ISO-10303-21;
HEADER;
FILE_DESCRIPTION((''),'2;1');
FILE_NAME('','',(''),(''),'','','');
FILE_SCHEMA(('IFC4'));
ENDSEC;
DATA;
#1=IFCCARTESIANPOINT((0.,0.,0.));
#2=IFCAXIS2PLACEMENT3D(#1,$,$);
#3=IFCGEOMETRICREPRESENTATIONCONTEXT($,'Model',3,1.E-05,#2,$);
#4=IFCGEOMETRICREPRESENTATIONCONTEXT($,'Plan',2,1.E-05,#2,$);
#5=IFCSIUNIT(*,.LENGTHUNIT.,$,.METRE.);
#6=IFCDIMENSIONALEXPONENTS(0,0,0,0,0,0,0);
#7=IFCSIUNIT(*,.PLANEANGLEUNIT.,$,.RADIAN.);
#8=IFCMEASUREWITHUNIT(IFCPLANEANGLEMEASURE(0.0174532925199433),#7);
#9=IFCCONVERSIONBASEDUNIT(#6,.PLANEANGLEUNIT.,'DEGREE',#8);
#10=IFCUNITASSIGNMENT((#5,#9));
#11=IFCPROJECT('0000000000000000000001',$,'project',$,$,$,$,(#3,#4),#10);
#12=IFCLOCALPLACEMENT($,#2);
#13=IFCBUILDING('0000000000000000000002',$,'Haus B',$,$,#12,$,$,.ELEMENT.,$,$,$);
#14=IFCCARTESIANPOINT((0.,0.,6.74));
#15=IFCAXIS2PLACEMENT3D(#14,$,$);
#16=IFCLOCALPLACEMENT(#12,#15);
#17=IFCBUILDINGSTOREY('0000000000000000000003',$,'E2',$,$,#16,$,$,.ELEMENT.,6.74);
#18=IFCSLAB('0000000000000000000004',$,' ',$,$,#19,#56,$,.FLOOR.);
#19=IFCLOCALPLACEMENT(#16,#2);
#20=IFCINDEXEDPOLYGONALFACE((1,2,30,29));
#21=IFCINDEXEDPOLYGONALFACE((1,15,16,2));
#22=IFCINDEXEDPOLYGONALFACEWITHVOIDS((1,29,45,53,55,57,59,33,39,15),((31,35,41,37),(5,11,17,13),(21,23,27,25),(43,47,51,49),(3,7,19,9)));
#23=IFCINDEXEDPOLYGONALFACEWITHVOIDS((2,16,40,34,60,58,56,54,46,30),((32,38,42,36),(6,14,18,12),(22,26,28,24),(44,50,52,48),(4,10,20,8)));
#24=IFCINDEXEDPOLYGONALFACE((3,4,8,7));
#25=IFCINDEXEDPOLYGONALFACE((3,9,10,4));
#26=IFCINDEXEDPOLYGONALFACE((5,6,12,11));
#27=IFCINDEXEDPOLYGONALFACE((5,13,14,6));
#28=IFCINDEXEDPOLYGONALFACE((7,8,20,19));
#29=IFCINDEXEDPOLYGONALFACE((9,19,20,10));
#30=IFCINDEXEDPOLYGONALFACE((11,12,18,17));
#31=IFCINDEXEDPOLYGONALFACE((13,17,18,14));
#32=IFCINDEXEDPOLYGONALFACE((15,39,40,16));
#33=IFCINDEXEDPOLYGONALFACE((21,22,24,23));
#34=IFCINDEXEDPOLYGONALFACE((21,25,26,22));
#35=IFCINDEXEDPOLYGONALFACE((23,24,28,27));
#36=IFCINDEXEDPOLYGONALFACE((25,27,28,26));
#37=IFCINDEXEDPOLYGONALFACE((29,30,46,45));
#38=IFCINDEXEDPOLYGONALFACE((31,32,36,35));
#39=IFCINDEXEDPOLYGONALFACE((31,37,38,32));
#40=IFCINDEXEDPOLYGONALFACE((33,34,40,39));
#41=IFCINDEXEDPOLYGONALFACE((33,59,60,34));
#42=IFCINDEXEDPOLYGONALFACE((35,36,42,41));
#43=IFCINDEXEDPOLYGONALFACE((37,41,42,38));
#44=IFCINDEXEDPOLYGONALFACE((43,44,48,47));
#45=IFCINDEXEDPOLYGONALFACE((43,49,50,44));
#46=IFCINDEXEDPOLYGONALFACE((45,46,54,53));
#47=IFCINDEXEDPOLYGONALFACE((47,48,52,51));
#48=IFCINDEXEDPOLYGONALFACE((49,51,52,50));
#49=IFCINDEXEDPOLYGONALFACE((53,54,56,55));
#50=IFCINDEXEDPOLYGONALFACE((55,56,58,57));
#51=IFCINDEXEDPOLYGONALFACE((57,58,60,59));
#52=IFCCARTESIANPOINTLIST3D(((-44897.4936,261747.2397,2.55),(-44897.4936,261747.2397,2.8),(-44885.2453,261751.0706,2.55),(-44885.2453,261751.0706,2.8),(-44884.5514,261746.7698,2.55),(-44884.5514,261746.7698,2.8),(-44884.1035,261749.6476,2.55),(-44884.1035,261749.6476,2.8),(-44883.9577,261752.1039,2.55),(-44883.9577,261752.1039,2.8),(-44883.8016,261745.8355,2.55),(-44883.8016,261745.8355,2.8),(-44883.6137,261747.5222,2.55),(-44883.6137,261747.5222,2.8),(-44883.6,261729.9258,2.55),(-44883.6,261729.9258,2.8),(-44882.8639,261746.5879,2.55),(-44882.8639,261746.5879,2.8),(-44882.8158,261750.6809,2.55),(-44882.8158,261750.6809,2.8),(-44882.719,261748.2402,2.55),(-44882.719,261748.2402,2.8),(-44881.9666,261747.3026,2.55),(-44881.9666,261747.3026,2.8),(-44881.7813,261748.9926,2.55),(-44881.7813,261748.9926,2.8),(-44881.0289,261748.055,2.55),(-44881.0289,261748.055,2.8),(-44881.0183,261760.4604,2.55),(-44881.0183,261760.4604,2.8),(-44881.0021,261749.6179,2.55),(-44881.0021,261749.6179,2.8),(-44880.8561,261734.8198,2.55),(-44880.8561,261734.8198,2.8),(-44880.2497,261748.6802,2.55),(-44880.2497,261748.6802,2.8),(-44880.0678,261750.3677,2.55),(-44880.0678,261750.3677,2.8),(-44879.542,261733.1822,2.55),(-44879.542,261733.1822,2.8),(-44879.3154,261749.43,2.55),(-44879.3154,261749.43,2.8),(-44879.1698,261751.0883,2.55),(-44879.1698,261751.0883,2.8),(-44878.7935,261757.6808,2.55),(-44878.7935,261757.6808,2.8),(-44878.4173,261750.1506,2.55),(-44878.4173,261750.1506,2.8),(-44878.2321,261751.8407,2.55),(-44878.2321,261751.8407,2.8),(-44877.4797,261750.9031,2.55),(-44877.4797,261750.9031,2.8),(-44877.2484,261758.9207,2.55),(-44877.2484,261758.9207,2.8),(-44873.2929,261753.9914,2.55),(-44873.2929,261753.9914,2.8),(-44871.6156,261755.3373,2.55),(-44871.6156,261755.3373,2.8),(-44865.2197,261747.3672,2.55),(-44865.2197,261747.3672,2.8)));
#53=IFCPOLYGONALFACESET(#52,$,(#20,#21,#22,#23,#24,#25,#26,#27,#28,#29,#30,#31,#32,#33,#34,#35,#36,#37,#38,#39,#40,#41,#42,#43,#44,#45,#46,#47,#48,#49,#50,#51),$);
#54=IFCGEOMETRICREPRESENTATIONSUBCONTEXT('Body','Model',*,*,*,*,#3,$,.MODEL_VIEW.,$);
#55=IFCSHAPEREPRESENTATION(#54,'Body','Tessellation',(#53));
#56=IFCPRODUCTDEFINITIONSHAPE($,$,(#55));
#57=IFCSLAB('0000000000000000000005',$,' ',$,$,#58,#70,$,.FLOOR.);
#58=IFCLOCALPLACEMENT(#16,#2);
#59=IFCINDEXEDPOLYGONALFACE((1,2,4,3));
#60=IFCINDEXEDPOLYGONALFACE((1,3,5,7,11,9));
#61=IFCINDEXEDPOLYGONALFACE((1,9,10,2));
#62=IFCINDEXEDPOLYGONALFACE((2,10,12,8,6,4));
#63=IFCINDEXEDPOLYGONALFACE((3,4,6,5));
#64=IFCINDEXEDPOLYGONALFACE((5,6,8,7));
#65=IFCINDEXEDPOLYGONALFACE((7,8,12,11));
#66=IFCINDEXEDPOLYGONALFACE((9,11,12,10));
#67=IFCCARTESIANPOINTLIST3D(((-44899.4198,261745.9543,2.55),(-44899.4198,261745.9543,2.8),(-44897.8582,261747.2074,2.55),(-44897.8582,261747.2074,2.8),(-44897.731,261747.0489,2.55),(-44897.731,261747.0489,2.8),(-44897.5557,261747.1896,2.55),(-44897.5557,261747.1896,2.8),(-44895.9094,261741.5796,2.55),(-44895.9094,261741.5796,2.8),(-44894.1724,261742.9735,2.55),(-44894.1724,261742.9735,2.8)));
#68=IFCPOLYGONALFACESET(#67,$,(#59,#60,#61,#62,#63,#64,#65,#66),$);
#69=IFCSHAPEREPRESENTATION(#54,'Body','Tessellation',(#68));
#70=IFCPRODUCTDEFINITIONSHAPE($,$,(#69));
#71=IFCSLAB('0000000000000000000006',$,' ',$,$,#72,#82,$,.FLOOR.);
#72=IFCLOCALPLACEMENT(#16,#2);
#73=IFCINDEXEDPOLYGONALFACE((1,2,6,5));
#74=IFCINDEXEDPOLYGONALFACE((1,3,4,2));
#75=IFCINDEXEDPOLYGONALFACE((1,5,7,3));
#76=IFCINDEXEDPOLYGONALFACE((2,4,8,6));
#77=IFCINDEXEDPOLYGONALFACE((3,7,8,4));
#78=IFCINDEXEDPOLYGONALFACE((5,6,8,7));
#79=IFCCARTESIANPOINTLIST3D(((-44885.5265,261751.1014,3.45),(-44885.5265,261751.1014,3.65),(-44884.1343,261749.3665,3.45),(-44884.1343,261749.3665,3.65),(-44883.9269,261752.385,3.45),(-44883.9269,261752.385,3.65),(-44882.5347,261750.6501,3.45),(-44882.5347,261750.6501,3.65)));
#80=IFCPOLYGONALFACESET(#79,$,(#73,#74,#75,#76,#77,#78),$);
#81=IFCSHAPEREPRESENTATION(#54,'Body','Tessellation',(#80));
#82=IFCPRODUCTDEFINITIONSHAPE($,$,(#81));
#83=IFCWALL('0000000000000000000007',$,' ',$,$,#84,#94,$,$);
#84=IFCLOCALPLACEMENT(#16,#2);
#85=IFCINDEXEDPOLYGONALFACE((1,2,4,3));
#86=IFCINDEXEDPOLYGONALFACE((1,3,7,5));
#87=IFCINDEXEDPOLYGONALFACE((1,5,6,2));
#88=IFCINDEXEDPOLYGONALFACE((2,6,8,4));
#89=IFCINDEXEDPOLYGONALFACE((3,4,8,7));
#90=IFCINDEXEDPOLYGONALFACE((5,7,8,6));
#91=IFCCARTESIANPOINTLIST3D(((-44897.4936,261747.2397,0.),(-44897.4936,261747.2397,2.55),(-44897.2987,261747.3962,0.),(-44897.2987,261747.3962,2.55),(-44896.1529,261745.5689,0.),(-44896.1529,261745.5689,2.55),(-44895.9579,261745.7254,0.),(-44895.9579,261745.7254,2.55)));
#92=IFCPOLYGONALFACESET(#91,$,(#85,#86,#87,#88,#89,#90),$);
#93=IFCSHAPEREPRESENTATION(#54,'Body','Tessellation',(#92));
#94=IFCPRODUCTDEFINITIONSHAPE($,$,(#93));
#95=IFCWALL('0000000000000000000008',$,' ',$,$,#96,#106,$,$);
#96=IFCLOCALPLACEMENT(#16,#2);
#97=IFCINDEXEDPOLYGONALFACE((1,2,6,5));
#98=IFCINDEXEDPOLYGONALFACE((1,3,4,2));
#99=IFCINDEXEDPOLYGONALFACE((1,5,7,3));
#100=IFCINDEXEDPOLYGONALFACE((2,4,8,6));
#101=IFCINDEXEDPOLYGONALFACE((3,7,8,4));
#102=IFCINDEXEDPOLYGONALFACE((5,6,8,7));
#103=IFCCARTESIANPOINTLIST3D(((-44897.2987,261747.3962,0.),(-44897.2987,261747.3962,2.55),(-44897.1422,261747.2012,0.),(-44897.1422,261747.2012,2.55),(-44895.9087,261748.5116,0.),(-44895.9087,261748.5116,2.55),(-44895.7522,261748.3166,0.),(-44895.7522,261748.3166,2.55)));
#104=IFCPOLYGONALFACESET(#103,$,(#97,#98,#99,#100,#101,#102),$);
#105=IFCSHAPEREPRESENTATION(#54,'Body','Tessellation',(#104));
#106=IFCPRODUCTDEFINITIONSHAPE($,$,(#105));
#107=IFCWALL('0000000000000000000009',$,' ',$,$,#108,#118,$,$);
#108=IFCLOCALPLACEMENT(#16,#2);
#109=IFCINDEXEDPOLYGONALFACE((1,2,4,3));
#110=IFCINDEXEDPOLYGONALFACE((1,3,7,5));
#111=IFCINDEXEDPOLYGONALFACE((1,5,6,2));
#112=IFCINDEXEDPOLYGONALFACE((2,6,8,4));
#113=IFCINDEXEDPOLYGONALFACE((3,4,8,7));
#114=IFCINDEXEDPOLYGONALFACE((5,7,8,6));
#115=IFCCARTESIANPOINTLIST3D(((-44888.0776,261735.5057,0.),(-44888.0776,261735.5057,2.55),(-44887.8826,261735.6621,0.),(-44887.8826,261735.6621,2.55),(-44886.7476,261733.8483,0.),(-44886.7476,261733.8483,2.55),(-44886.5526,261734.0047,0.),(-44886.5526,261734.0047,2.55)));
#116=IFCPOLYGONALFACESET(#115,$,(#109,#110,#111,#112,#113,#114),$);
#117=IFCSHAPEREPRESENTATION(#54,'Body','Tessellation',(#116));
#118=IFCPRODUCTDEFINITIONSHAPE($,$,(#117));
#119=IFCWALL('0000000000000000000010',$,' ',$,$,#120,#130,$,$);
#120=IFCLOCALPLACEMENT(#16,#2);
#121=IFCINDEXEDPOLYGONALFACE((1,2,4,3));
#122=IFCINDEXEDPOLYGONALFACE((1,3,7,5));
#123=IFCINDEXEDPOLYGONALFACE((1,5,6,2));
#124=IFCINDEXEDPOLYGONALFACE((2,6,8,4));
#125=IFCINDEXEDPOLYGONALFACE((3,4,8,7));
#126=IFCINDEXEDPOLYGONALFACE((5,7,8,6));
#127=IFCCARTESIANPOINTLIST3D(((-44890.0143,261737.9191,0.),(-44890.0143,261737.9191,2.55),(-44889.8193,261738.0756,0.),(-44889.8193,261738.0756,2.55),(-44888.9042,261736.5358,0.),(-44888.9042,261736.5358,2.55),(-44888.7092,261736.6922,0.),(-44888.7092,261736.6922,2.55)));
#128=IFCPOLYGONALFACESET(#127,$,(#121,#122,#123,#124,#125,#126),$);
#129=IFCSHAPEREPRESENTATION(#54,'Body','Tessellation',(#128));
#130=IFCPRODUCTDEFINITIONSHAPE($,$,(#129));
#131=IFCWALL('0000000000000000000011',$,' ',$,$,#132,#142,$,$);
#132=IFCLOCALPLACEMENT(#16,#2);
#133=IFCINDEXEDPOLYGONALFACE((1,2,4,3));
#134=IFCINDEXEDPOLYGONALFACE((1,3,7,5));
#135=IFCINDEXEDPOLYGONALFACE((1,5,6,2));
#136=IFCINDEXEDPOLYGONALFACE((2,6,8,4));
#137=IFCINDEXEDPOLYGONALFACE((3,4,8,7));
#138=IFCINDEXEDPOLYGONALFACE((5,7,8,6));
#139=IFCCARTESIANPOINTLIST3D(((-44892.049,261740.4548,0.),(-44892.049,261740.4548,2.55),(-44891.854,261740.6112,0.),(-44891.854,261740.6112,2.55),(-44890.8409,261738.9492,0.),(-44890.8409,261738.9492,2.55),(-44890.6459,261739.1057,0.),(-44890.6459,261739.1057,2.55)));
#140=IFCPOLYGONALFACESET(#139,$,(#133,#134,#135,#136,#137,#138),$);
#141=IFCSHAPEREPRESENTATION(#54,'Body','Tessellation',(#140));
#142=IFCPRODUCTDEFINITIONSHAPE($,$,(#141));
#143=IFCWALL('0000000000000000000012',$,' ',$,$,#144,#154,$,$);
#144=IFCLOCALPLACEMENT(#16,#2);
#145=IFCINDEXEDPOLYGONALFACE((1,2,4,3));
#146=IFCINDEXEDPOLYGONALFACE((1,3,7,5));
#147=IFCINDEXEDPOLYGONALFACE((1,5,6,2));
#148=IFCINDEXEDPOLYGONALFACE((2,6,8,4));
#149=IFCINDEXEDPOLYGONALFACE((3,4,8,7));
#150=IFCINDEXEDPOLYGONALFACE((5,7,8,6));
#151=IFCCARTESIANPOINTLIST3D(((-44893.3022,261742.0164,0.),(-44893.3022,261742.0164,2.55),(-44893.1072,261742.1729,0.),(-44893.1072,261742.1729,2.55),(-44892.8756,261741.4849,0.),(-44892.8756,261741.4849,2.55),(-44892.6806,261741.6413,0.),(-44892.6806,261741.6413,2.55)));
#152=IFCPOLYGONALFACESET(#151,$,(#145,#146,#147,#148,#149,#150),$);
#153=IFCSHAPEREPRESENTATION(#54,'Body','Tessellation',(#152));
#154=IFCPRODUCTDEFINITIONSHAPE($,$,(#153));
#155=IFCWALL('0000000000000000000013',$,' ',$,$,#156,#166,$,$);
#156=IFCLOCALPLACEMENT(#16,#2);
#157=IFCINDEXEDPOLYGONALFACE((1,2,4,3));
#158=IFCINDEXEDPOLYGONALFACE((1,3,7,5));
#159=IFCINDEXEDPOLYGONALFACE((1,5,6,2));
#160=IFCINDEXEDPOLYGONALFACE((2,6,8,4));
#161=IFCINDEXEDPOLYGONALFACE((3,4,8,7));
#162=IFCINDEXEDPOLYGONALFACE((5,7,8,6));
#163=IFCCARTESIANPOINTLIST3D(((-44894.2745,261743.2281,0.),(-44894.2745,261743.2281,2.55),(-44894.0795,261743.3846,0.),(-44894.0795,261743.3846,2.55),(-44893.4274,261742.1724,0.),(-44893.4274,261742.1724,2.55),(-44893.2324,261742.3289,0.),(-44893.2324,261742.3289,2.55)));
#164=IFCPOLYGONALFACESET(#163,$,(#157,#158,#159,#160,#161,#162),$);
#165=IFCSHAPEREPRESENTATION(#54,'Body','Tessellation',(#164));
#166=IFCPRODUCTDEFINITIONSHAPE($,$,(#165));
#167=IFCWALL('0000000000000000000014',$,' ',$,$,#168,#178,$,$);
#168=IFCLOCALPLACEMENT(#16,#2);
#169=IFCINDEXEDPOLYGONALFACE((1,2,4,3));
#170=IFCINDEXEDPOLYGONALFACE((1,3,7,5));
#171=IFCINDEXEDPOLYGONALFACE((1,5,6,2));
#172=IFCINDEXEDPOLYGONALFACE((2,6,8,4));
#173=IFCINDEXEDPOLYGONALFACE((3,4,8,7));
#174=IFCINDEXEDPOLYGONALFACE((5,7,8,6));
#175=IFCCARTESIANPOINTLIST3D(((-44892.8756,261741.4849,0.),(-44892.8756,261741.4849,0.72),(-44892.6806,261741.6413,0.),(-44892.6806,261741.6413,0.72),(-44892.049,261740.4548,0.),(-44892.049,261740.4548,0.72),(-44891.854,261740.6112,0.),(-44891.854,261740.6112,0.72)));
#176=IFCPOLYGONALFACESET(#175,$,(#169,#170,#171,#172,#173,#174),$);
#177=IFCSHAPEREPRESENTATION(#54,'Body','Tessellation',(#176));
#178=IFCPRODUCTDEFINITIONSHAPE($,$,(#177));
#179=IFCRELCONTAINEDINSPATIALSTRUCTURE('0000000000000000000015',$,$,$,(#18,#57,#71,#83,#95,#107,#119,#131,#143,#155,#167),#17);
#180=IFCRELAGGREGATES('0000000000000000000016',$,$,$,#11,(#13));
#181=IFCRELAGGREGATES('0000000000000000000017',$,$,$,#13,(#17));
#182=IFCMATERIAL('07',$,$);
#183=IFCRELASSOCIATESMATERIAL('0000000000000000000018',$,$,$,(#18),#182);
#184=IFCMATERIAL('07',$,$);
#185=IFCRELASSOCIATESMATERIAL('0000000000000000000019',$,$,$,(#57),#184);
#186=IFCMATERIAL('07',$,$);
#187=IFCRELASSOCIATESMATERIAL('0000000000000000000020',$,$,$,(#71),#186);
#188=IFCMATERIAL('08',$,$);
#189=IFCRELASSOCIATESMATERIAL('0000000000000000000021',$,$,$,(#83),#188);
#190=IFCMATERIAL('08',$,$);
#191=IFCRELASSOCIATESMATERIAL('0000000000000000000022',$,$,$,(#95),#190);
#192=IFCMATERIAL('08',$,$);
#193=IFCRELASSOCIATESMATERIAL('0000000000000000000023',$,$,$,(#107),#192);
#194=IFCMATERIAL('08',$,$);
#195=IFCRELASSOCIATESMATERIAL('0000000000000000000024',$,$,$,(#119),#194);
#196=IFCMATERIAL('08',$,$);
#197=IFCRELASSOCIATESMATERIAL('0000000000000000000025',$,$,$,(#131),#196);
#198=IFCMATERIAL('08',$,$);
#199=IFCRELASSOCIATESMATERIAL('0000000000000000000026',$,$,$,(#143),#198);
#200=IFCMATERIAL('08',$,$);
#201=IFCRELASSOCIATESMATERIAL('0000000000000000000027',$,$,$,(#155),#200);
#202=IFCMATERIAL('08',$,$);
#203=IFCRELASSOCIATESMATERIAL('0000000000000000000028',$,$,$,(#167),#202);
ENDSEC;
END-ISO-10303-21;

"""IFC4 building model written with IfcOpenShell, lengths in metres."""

from ifc_helpers import new_model, entity, si_unit, converted_unit, frame, frame_2d, origin, origin_with_axes, place, context, subcontext, project, spatial, polyline, rectangle, outline, extrude, material, element, save


model = new_model("IFC4")

# Units and contexts
model_context = context("Model", 3, precision=1e-05, world=origin())
plan_context = context("Plan", 2, precision=1e-05, world=origin())
body_context = subcontext(model_context, "Body", "Model", "MODEL_VIEW")
ifc_project = project(units=[si_unit("LENGTHUNIT", "METRE"), converted_unit("PLANEANGLEUNIT", "DEGREE", entity("IfcPlaneAngleMeasure", 0.0174532925199433), si_unit("PLANEANGLEUNIT", "RADIAN"), dimensions=[0, 0, 0, 0, 0, 0, 0])], contexts=[model_context, plan_context])

# Building, storey
building_placement = place(None, origin())
building = spatial("IfcBuilding", under=ifc_project, at=building_placement, Name="Haus B", CompositionType="ELEMENT")
storey_placement = place(building_placement, frame((0.0, 0.0, 6.74)))
storey = spatial("IfcBuildingStorey", under=building, at=storey_placement, Name="E2", CompositionType="ELEMENT", Elevation=6.74)

# Slab, openings
ifc_material_1 = material(Name="07")
slab_1_placement = place(storey_placement, frame((-44897.4936, 261729.9258, 2.55)))
slab_1 = element("IfcSlab", 1, at=slab_1_placement, inside=storey, material=ifc_material_1, Name=" ", PredefinedType="FLOOR", context=body_context, shape_type="SweptSolid", body=[
    extrude(outline(polyline([(0.0, 17.3139), (13.8936, 0.0), (17.9517, 3.2564), (16.6376, 4.894), (32.2739, 17.4414), (25.878, 25.4115), (24.2008, 24.0656), (20.2453, 28.9949), (18.7001, 27.755), (16.4753, 30.5346), (0.0, 17.3139)])), origin_with_axes(), (0.0, 0.0, 1.0), 0.25),
])
opening_1_placement = place(slab_1_placement, frame((18.3239, 20.2249, 0.0)))
element("IfcOpeningStandardCase", 2, at=opening_1_placement, cuts=slab_1, PredefinedType="OPENING", context=body_context, shape_type="SweptSolid", body=[
    extrude(rectangle(XDim=1.2022, YDim=1.2022, at=frame_2d((0.0, 0.0), x_axis=(0.625861, -0.779935))), frame((0.845, 0.845, 0.0), z_axis=(0.0, 0.0, 1.0), x_axis=(1.0, 0.0, 0.0)), (0.0, 0.0, 1.0), 0.25),
])
opening_2_placement = place(slab_1_placement, frame((16.4915, 18.7544, 0.0)))
element("IfcOpeningStandardCase", 3, at=opening_2_placement, cuts=slab_1, PredefinedType="OPENING", context=body_context, shape_type="SweptSolid", body=[
    extrude(rectangle(XDim=1.198, YDim=1.2022, at=frame_2d((0.0, 0.0), x_axis=(0.779935, 0.625861))), frame((0.8434, 0.8437, 0.0), z_axis=(0.0, 0.0, 1.0), x_axis=(1.0, 0.0, 0.0)), (0.0, 0.0, 1.0), 0.25),
])
opening_3_placement = place(slab_1_placement, frame((14.7747, 17.3768, 0.0)))
element("IfcOpeningStandardCase", 4, at=opening_3_placement, cuts=slab_1, PredefinedType="OPENING", context=body_context, shape_type="SweptSolid", body=[
    extrude(rectangle(XDim=1.2022, YDim=1.2022, at=frame_2d((0.0, 0.0), x_axis=(0.625861, -0.779935))), frame((0.845, 0.845, 0.0), z_axis=(0.0, 0.0, 1.0), x_axis=(1.0, 0.0, 0.0)), (0.0, 0.0, 1.0), 0.25),
])
opening_4_placement = place(slab_1_placement, frame((12.9423, 15.9097, 0.0)))
element("IfcOpeningStandardCase", 5, at=opening_4_placement, cuts=slab_1, PredefinedType="OPENING", context=body_context, shape_type="SweptSolid", body=[
    extrude(rectangle(XDim=1.198, YDim=1.2022, at=frame_2d((0.0, 0.0), x_axis=(0.625861, -0.779935))), frame((0.8437, 0.8434, 0.0), z_axis=(0.0, 0.0, 1.0), x_axis=(1.0, 0.0, 0.0)), (0.0, 0.0, 1.0), 0.25),
])
opening_5_placement = place(slab_1_placement, frame((12.2483, 19.7218, 0.0)))
element("IfcOpeningStandardCase", 6, at=opening_5_placement, cuts=slab_1, PredefinedType="OPENING", context=body_context, shape_type="SweptSolid", body=[
    extrude(rectangle(XDim=1.6509, YDim=1.8245, at=frame_2d((0.0, 0.0), x_axis=(-0.779935, -0.625861))), frame((1.2148, 1.2281, 0.0), z_axis=(0.0, 0.0, 1.0), x_axis=(1.0, 0.0, 0.0)), (0.0, 0.0, 1.0), 0.25),
])

# Slabs
ifc_material_2 = material(Name="07")
slab_2_placement = place(storey_placement, frame((-44899.4198, 261741.5796, 2.55)))
element("IfcSlab", 7, at=slab_2_placement, inside=storey, material=ifc_material_2, Name=" ", PredefinedType="FLOOR", context=body_context, shape_type="SweptSolid", body=[
    extrude(outline(polyline([(1.8641, 5.61), (1.6888, 5.4693), (1.5617, 5.6278), (0.0, 4.3746), (3.5104, 0.0), (5.2474, 1.3938), (1.8641, 5.61)])), origin_with_axes(), (0.0, 0.0, 1.0), 0.25),
])
ifc_material_3 = material(Name="07")
slab_3_placement = place(storey_placement, frame((-44885.5265, 261749.3665, 3.45)))
element("IfcSlab", 8, at=slab_3_placement, inside=storey, material=ifc_material_3, Name=" ", PredefinedType="FLOOR", context=body_context, shape_type="SweptSolid", body=[
    extrude(rectangle(XDim=2.0509, YDim=2.2245, at=frame_2d((-0.1037, -1.5093), x_axis=(-0.779935, -0.625861))), frame((1.5996, 3.0186, 0.0), z_axis=(0.0, 0.0, 1.0), x_axis=(1.0, 0.0, 0.0)), (0.0, 0.0, 1.0), 0.2),
])

# Walls
ifc_material_4 = material(Name="08")
wall_1_placement = place(storey_placement, frame((-44895.9579, 261745.7254, 0.0), z_axis=(0.0, 0.0, 1.0), x_axis=(-0.625861, 0.779935, 0.0)))
element("IfcWall", 9, at=wall_1_placement, inside=storey, material=ifc_material_4, Name=" ", context=body_context, shape_type="SweptSolid", body=[
    extrude(rectangle(XDim=2.1422, YDim=0.25, at=frame_2d((1.0711, 0.125), x_axis=(1.0, 0.0))), origin_with_axes(), (0.0, 0.0, 1.0), 2.55),
])
ifc_material_5 = material(Name="08")
wall_2_placement = place(storey_placement, frame((-44897.1422, 261747.2012, 0.0), z_axis=(0.0, 0.0, 1.0), x_axis=(0.779935, 0.625861, 0.0)))
element("IfcWall", 10, at=wall_2_placement, inside=storey, material=ifc_material_5, Name=" ", context=body_context, shape_type="SweptSolid", body=[
    extrude(rectangle(XDim=1.7822, YDim=0.25, at=frame_2d((0.8911, 0.125), x_axis=(1.0, 0.0))), origin_with_axes(), (0.0, 0.0, 1.0), 2.55),
])
ifc_material_6 = material(Name="08")
wall_3_placement = place(storey_placement, frame((-44886.5526, 261734.0047, 0.0), z_axis=(0.0, 0.0, 1.0), x_axis=(-0.625861, 0.779935, 0.0)))
element("IfcWall", 11, at=wall_3_placement, inside=storey, material=ifc_material_6, Name=" ", context=body_context, shape_type="SweptSolid", body=[
    extrude(rectangle(XDim=2.1251, YDim=0.25, at=frame_2d((1.0625, 0.125), x_axis=(1.0, 0.0))), origin_with_axes(), (0.0, 0.0, 1.0), 2.55),
])
ifc_material_7 = material(Name="08")
wall_4_placement = place(storey_placement, frame((-44888.7092, 261736.6922, 0.0), z_axis=(0.0, 0.0, 1.0), x_axis=(-0.625861, 0.779935, 0.0)))
element("IfcWall", 12, at=wall_4_placement, inside=storey, material=ifc_material_7, Name=" ", context=body_context, shape_type="SweptSolid", body=[
    extrude(rectangle(XDim=1.7737, YDim=0.25, at=frame_2d((0.8868, 0.125), x_axis=(1.0, 0.0))), origin_with_axes(), (0.0, 0.0, 1.0), 2.55),
])
ifc_material_8 = material(Name="08")
wall_5_placement = place(storey_placement, frame((-44890.6459, 261739.1057, 0.0), z_axis=(0.0, 0.0, 1.0), x_axis=(-0.625861, 0.779935, 0.0)))
element("IfcWall", 13, at=wall_5_placement, inside=storey, material=ifc_material_8, Name=" ", context=body_context, shape_type="SweptSolid", body=[
    extrude(rectangle(XDim=1.9303, YDim=0.25, at=frame_2d((0.9652, 0.125), x_axis=(1.0, 0.0))), origin_with_axes(), (0.0, 0.0, 1.0), 2.55),
])
ifc_material_9 = material(Name="08")
wall_6_placement = place(storey_placement, frame((-44892.6806, 261741.6413, 0.0), z_axis=(0.0, 0.0, 1.0), x_axis=(-0.625861, 0.779935, 0.0)))
element("IfcWall", 14, at=wall_6_placement, inside=storey, material=ifc_material_9, Name=" ", context=body_context, shape_type="SweptSolid", body=[
    extrude(rectangle(XDim=0.6815, YDim=0.25, at=frame_2d((0.3408, 0.125), x_axis=(1.0, 0.0))), origin_with_axes(), (0.0, 0.0, 1.0), 2.55),
])
ifc_material_10 = material(Name="08")
wall_7_placement = place(storey_placement, frame((-44893.2324, 261742.3289, 0.0), z_axis=(0.0, 0.0, 1.0), x_axis=(-0.625861, 0.779935, 0.0)))
element("IfcWall", 15, at=wall_7_placement, inside=storey, material=ifc_material_10, Name=" ", context=body_context, shape_type="SweptSolid", body=[
    extrude(rectangle(XDim=1.3536, YDim=0.25, at=frame_2d((0.6768, 0.125), x_axis=(1.0, 0.0))), origin_with_axes(), (0.0, 0.0, 1.0), 2.55),
])
ifc_material_11 = material(Name="08")
wall_8_placement = place(storey_placement, frame((-44891.854, 261740.6112, 0.0), z_axis=(0.0, 0.0, 1.0), x_axis=(-0.625861, 0.779935, 0.0)))
element("IfcWall", 16, at=wall_8_placement, inside=storey, material=ifc_material_11, Name=" ", context=body_context, shape_type="SweptSolid", body=[
    extrude(rectangle(XDim=1.3207, YDim=0.25, at=frame_2d((0.6604, 0.125), x_axis=(1.0, 0.0))), origin_with_axes(), (0.0, 0.0, 1.0), 0.72),
])

save(model, "model.ifc")
